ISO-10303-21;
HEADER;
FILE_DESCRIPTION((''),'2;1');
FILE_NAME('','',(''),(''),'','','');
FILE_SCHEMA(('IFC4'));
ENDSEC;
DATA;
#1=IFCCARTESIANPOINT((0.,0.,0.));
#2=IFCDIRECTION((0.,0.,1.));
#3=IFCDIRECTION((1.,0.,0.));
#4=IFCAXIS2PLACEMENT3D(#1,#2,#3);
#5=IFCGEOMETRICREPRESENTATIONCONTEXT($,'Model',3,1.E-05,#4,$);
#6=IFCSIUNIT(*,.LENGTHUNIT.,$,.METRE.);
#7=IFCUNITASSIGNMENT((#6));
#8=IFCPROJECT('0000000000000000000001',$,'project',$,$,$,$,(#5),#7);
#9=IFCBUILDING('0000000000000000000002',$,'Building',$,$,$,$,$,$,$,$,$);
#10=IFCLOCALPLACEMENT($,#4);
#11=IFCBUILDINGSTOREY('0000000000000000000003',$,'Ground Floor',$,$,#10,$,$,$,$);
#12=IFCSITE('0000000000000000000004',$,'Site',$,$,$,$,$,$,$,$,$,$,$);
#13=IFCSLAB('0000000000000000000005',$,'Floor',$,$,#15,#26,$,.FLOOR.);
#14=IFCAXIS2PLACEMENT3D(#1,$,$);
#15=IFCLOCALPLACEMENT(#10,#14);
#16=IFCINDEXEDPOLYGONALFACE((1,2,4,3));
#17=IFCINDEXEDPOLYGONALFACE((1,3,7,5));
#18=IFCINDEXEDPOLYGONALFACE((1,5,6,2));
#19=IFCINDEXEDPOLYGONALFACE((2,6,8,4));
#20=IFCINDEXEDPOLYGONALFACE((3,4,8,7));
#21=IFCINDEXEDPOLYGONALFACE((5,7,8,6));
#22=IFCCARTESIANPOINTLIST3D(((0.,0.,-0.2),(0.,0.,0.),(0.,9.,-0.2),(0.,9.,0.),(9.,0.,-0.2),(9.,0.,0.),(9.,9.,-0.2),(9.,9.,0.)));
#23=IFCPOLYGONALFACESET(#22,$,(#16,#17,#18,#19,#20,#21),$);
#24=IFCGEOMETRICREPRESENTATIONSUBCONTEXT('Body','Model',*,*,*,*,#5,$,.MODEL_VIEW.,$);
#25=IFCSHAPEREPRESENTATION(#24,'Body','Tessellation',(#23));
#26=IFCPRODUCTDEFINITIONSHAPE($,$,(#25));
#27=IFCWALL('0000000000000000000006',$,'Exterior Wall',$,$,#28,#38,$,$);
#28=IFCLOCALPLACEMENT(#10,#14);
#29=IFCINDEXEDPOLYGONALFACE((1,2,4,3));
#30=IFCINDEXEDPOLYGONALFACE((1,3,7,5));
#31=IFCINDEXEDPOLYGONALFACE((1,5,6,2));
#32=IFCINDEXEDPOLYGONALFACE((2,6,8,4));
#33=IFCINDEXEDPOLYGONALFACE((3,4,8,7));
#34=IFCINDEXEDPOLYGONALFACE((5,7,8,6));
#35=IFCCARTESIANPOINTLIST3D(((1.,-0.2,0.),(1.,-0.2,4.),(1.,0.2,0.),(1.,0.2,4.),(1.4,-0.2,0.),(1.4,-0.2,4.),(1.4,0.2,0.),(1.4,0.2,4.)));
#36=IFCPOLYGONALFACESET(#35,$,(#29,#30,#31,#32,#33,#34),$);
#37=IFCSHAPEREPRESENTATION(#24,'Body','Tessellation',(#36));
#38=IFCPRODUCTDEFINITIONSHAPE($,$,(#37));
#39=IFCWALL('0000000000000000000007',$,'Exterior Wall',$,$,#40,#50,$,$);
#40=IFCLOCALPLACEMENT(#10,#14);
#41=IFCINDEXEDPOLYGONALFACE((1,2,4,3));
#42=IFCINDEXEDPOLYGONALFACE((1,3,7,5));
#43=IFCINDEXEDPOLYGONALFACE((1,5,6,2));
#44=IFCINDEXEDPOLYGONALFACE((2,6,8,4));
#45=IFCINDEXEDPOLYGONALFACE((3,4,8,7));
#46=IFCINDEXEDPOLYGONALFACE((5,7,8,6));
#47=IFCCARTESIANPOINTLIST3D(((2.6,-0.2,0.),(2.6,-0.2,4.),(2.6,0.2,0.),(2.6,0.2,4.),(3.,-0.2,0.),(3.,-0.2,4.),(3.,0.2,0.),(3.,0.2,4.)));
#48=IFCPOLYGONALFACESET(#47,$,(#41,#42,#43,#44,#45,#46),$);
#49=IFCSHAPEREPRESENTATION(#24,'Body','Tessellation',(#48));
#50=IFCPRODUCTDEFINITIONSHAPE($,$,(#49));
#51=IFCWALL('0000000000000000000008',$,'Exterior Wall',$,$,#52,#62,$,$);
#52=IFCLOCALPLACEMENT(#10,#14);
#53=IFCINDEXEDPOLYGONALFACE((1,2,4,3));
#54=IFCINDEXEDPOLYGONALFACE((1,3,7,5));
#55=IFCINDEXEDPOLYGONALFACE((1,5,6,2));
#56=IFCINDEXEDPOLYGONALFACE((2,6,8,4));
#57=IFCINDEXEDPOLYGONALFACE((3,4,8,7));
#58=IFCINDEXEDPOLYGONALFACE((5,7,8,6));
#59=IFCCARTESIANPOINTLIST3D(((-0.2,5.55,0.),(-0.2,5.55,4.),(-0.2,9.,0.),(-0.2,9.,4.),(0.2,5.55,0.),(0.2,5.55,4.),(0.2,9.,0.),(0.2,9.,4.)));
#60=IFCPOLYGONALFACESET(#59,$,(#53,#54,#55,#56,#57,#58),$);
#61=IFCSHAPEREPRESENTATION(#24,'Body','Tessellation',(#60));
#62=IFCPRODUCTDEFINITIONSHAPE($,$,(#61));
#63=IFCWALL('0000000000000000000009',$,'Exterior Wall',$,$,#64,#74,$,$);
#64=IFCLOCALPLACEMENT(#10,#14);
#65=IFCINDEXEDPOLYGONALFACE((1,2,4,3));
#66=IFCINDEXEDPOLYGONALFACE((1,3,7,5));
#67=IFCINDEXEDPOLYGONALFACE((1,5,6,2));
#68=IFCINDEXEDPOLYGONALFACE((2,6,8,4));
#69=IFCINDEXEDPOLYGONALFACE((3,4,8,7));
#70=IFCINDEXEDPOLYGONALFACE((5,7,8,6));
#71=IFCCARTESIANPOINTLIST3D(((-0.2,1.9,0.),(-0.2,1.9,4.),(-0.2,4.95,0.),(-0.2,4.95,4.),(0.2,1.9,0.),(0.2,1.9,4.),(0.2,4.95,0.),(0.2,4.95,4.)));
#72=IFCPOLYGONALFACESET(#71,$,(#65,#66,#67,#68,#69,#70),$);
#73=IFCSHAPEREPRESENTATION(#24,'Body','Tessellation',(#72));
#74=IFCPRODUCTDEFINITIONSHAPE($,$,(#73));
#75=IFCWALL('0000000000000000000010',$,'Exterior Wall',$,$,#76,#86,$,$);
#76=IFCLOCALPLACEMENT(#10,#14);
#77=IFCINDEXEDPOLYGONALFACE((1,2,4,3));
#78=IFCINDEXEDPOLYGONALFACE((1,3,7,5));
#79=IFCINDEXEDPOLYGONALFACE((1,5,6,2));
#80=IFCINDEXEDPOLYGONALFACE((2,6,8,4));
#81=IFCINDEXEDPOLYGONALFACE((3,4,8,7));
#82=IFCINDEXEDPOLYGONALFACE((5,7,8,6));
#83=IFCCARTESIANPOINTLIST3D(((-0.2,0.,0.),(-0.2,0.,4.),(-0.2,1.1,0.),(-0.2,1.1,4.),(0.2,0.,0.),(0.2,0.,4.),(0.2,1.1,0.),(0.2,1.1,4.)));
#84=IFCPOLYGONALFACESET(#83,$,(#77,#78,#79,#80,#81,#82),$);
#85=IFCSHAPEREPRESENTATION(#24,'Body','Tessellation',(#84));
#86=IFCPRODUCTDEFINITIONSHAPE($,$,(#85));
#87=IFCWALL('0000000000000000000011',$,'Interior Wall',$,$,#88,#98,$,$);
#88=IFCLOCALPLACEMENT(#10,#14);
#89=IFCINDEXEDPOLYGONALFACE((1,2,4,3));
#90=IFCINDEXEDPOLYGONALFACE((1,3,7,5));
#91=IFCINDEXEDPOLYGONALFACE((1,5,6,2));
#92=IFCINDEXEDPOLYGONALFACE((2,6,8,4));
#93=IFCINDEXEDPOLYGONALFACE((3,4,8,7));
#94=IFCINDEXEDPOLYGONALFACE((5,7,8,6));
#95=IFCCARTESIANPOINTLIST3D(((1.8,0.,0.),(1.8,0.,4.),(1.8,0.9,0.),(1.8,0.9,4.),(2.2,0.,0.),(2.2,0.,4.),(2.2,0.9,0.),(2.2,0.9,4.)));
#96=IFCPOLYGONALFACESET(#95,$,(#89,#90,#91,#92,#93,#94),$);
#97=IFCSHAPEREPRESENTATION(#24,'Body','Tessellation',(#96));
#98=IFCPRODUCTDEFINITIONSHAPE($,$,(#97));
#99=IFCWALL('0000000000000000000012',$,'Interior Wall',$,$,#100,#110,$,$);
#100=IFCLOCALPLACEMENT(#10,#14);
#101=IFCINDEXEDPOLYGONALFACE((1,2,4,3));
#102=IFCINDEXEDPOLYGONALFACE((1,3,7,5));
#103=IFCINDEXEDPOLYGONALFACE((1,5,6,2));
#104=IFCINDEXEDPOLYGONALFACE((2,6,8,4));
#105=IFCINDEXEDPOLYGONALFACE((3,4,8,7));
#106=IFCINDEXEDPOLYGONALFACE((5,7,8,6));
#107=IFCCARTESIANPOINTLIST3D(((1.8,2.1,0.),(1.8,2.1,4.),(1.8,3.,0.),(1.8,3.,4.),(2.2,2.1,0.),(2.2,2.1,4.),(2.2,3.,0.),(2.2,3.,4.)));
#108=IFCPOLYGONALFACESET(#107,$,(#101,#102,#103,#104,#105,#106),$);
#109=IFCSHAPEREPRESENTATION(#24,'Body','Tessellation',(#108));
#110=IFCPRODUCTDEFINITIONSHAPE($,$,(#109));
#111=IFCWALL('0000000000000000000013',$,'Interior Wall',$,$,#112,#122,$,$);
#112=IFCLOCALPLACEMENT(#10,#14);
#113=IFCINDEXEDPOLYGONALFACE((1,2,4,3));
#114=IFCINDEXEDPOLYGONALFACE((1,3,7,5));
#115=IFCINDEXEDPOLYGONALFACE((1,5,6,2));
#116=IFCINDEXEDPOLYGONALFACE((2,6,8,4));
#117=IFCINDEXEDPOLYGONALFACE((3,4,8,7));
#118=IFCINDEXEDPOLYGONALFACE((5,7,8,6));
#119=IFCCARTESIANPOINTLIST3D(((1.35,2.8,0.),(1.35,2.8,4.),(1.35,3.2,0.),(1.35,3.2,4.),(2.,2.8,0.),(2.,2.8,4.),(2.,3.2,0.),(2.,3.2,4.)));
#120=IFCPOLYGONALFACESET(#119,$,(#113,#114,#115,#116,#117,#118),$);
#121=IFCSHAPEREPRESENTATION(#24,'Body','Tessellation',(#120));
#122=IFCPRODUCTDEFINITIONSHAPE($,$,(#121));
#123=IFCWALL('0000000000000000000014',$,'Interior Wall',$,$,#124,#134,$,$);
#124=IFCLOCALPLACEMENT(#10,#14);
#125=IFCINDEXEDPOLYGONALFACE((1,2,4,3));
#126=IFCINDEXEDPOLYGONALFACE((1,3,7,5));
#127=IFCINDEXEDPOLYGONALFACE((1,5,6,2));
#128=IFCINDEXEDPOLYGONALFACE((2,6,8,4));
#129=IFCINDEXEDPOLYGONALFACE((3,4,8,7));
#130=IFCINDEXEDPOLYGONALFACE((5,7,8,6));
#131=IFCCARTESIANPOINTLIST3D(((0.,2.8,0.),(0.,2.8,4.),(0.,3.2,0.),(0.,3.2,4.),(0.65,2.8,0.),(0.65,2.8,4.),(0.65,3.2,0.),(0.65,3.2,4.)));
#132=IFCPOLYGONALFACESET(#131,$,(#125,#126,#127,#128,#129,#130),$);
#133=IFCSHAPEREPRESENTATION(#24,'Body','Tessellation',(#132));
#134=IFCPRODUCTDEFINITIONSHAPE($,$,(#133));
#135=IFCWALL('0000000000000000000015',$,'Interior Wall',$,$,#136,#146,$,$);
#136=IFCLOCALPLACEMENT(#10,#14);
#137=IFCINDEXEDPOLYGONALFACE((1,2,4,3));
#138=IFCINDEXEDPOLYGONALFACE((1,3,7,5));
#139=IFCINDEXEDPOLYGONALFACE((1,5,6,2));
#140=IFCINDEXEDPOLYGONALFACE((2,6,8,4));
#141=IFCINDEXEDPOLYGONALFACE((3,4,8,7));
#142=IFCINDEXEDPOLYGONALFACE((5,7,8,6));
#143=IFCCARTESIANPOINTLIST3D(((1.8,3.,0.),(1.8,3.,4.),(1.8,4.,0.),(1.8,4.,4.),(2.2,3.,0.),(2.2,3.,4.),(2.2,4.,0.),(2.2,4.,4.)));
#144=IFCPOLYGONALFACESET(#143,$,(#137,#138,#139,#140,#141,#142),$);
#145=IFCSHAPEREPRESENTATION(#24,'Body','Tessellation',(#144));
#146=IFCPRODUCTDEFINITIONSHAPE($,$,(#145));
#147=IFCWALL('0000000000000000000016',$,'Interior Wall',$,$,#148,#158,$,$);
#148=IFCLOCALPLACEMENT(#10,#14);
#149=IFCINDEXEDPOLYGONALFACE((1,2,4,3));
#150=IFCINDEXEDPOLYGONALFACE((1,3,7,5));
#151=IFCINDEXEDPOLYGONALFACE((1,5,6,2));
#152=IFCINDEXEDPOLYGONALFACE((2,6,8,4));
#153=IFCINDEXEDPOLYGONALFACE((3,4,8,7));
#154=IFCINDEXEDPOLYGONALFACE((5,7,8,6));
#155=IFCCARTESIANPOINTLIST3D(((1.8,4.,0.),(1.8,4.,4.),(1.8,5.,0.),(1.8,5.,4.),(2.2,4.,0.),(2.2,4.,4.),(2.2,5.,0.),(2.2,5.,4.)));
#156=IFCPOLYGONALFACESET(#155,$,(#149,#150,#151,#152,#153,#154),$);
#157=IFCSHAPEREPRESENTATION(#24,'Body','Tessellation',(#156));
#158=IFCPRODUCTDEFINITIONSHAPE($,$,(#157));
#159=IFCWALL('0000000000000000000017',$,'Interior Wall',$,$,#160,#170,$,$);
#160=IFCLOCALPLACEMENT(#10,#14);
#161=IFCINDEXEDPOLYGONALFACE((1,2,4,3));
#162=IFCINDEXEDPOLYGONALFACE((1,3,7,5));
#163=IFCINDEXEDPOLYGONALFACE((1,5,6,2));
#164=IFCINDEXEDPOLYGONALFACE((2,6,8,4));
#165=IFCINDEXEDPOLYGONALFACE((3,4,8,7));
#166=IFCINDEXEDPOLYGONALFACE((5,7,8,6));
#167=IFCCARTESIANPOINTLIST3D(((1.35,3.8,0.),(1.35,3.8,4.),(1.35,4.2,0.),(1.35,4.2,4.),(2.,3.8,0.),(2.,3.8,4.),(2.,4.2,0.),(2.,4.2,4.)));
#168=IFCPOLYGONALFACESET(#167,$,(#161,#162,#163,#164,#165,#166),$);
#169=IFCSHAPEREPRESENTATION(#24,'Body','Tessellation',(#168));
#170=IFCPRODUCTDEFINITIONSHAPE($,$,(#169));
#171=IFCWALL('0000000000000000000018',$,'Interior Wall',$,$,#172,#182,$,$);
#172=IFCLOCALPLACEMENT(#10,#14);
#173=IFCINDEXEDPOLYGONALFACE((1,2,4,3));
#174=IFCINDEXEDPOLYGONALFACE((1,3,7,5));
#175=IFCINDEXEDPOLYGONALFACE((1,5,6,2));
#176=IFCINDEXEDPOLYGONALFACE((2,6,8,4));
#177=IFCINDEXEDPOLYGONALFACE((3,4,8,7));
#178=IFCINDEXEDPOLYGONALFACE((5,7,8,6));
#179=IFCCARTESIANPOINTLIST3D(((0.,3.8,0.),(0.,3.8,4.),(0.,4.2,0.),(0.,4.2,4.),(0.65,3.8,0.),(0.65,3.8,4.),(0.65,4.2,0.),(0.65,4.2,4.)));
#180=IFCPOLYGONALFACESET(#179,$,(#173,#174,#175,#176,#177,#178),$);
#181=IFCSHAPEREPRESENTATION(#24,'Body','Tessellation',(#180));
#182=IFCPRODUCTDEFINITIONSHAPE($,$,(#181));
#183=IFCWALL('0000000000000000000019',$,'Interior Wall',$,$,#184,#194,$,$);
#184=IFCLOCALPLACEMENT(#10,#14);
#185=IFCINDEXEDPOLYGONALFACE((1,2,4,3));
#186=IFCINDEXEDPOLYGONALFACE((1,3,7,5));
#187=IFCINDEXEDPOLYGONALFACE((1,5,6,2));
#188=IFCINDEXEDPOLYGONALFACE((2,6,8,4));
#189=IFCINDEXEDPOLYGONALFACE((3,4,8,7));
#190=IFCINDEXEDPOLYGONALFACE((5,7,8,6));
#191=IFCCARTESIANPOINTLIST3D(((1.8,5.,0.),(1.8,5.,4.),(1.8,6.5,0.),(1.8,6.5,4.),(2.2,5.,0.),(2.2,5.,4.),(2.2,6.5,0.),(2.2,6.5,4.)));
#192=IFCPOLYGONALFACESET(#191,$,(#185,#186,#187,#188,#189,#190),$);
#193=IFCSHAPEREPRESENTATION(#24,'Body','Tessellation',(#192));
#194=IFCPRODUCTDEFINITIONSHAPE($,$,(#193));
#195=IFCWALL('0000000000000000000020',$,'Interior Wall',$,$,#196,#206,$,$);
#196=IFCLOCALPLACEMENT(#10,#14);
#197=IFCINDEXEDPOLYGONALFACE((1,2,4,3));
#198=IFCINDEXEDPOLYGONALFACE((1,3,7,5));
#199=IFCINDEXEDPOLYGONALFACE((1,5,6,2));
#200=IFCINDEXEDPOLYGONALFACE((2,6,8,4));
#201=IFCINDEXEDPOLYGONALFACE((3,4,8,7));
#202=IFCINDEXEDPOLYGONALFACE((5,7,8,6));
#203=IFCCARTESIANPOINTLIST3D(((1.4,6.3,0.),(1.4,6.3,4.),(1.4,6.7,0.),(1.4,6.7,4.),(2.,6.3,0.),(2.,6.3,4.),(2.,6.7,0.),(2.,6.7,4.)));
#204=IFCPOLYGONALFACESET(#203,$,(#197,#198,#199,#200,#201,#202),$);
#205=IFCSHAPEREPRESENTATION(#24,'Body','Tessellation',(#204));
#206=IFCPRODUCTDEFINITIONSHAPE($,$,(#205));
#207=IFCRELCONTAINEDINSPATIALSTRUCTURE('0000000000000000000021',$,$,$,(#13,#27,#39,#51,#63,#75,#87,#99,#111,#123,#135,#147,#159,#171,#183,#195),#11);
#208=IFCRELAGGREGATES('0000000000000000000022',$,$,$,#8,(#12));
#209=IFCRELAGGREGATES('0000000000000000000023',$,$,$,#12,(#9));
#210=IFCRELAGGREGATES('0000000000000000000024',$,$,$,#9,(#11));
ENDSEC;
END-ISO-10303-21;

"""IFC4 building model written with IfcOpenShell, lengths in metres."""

from ifc_helpers import new_model, si_unit, frame, origin_with_axes, place, context, subcontext, project, spatial, indexed_curve, outline, extrude, element, save


model = new_model("IFC4")

# Units and contexts
model_context = context("Model", 3, precision=1e-05, world=origin_with_axes())
body_context = subcontext(model_context, "Body", "Model", "MODEL_VIEW")
ifc_project = project(units=[si_unit("LENGTHUNIT", "METRE")], contexts=[model_context])

# Site, building, storey
site = spatial("IfcSite", under=ifc_project, Name="Site")
building = spatial("IfcBuilding", under=site, Name="Building")
storey_placement = place(None, origin_with_axes())
storey = spatial("IfcBuildingStorey", under=building, at=storey_placement, Name="Ground Floor")

# Slab
slab_placement = place(storey_placement, frame((0.0, 0.0, -0.2), z_axis=(0.0, 0.0, 1.0), x_axis=(1.0, 0.0, 0.0)))
element("IfcSlab", 1, at=slab_placement, inside=storey, Name="Floor", PredefinedType="FLOOR", context=body_context, shape_type="SweptSolid", body=[
    extrude(outline(indexed_curve([(0.0, 0.0), (9.0, 0.0), (9.0, 9.0), (0.0, 9.0)])), None, (0.0, 0.0, 1.0), 0.2),
])

# Walls
for number, where, z_axis, x_axis, name in (
    (2, (1.0, 0.0, 0.0), (0.0, 0.0, 1.0), (1.0, 0.0, 0.0), "Exterior Wall"),
    (3, (2.6, 0.0, 0.0), (0.0, 0.0, 1.0), (1.0, 0.0, 0.0), "Exterior Wall"),
):
    element("IfcWall", number, at=place(storey_placement, frame(where, z_axis=z_axis, x_axis=x_axis)), inside=storey, Name=name, context=body_context, shape_type="SweptSolid", body=[
        extrude(outline(indexed_curve([(0.0, 0.0), (0.0, 0.4), (0.4, 0.4), (0.4, 0.0), (0.0, 0.0)], self_intersect=False)), frame((0.0, -0.2, 0.0), z_axis=(0.0, 0.0, 1.0), x_axis=(1.0, 0.0, 0.0)), (0.0, 0.0, 1.0), 4.0),
    ])
wall_1_placement = place(storey_placement, frame((0.0, 9.0, 0.0), z_axis=(0.0, 0.0, 1.0), x_axis=(0.0, -1.0, 0.0)))
element("IfcWall", 4, at=wall_1_placement, inside=storey, Name="Exterior Wall", context=body_context, shape_type="SweptSolid", body=[
    extrude(outline(indexed_curve([(0.0, 0.0), (0.0, 0.4), (3.45, 0.4), (3.45, 0.0), (0.0, 0.0)], self_intersect=False)), frame((0.0, -0.2, 0.0), z_axis=(0.0, 0.0, 1.0), x_axis=(1.0, 0.0, 0.0)), (0.0, 0.0, 1.0), 4.0),
])
wall_2_placement = place(storey_placement, frame((0.0, 4.95, 0.0), z_axis=(0.0, 0.0, 1.0), x_axis=(0.0, -1.0, 0.0)))
element("IfcWall", 5, at=wall_2_placement, inside=storey, Name="Exterior Wall", context=body_context, shape_type="SweptSolid", body=[
    extrude(outline(indexed_curve([(0.0, 0.0), (0.0, 0.4), (3.05, 0.4), (3.05, 0.0), (0.0, 0.0)], self_intersect=False)), frame((0.0, -0.2, 0.0), z_axis=(0.0, 0.0, 1.0), x_axis=(1.0, 0.0, 0.0)), (0.0, 0.0, 1.0), 4.0),
])
wall_3_placement = place(storey_placement, frame((0.0, 1.1, 0.0), z_axis=(0.0, 0.0, 1.0), x_axis=(0.0, -1.0, 0.0)))
element("IfcWall", 6, at=wall_3_placement, inside=storey, Name="Exterior Wall", context=body_context, shape_type="SweptSolid", body=[
    extrude(outline(indexed_curve([(0.0, 0.0), (0.0, 0.4), (1.1, 0.4), (1.1, 0.0), (0.0, 0.0)], self_intersect=False)), frame((0.0, -0.2, 0.0), z_axis=(0.0, 0.0, 1.0), x_axis=(1.0, 0.0, 0.0)), (0.0, 0.0, 1.0), 4.0),
])
wall_4_placement = place(storey_placement, frame((2.0, 0.0, 0.0), z_axis=(0.0, 0.0, 1.0), x_axis=(0.0, 1.0, 0.0)))
element("IfcWall", 7, at=wall_4_placement, inside=storey, Name="Interior Wall", context=body_context, shape_type="SweptSolid", body=[
    extrude(outline(indexed_curve([(0.0, 0.0), (0.0, 0.4), (0.9, 0.4), (0.9, 0.0), (0.0, 0.0)], self_intersect=False)), frame((0.0, -0.2, 0.0), z_axis=(0.0, 0.0, 1.0), x_axis=(1.0, 0.0, 0.0)), (0.0, 0.0, 1.0), 4.0),
])
wall_5_placement = place(storey_placement, frame((2.0, 2.1, 0.0), z_axis=(0.0, 0.0, 1.0), x_axis=(0.0, 1.0, 0.0)))
element("IfcWall", 8, at=wall_5_placement, inside=storey, Name="Interior Wall", context=body_context, shape_type="SweptSolid", body=[
    extrude(outline(indexed_curve([(0.0, 0.0), (0.0, 0.4), (0.9, 0.4), (0.9, 0.0), (0.0, 0.0)], self_intersect=False)), frame((0.0, -0.2, 0.0), z_axis=(0.0, 0.0, 1.0), x_axis=(1.0, 0.0, 0.0)), (0.0, 0.0, 1.0), 4.0),
])
for number, where, z_axis, x_axis, name in (
    (9, (2.0, 3.0, 0.0), (0.0, 0.0, 1.0), (-1.0, 0.0, 0.0), "Interior Wall"),
    (10, (0.65, 3.0, 0.0), (0.0, 0.0, 1.0), (-1.0, 0.0, 0.0), "Interior Wall"),
):
    element("IfcWall", number, at=place(storey_placement, frame(where, z_axis=z_axis, x_axis=x_axis)), inside=storey, Name=name, context=body_context, shape_type="SweptSolid", body=[
        extrude(outline(indexed_curve([(0.0, 0.0), (0.0, 0.4), (0.65, 0.4), (0.65, 0.0), (0.0, 0.0)], self_intersect=False)), frame((0.0, -0.2, 0.0), z_axis=(0.0, 0.0, 1.0), x_axis=(1.0, 0.0, 0.0)), (0.0, 0.0, 1.0), 4.0),
    ])
for number, where, z_axis, x_axis, name in (
    (11, (2.0, 4.0, 0.0), (0.0, 0.0, 1.0), (0.0, -1.0, 0.0), "Interior Wall"),
    (12, (2.0, 5.0, 0.0), (0.0, 0.0, 1.0), (0.0, -1.0, 0.0), "Interior Wall"),
):
    element("IfcWall", number, at=place(storey_placement, frame(where, z_axis=z_axis, x_axis=x_axis)), inside=storey, Name=name, context=body_context, shape_type="SweptSolid", body=[
        extrude(outline(indexed_curve([(0.0, 0.0), (0.0, 0.4), (1.0, 0.4), (1.0, 0.0), (0.0, 0.0)], self_intersect=False)), frame((0.0, -0.2, 0.0), z_axis=(0.0, 0.0, 1.0), x_axis=(1.0, 0.0, 0.0)), (0.0, 0.0, 1.0), 4.0),
    ])
for number, where, z_axis, x_axis, name in (
    (13, (2.0, 4.0, 0.0), (0.0, 0.0, 1.0), (-1.0, 0.0, 0.0), "Interior Wall"),
    (14, (0.65, 4.0, 0.0), (0.0, 0.0, 1.0), (-1.0, 0.0, 0.0), "Interior Wall"),
):
    element("IfcWall", number, at=place(storey_placement, frame(where, z_axis=z_axis, x_axis=x_axis)), inside=storey, Name=name, context=body_context, shape_type="SweptSolid", body=[
        extrude(outline(indexed_curve([(0.0, 0.0), (0.0, 0.4), (0.65, 0.4), (0.65, 0.0), (0.0, 0.0)], self_intersect=False)), frame((0.0, -0.2, 0.0), z_axis=(0.0, 0.0, 1.0), x_axis=(1.0, 0.0, 0.0)), (0.0, 0.0, 1.0), 4.0),
    ])
wall_6_placement = place(storey_placement, frame((2.0, 5.0, 0.0), z_axis=(0.0, 0.0, 1.0), x_axis=(0.0, 1.0, 0.0)))
element("IfcWall", 15, at=wall_6_placement, inside=storey, Name="Interior Wall", context=body_context, shape_type="SweptSolid", body=[
    extrude(outline(indexed_curve([(0.0, 0.0), (0.0, 0.4), (1.5, 0.4), (1.5, 0.0), (0.0, 0.0)], self_intersect=False)), frame((0.0, -0.2, 0.0), z_axis=(0.0, 0.0, 1.0), x_axis=(1.0, 0.0, 0.0)), (0.0, 0.0, 1.0), 4.0),
])
for number, where, z_axis, x_axis, name in (
    (16, (2.0, 6.5, 0.0), (0.0, 0.0, 1.0), (-1.0, 0.0, 0.0), "Interior Wall"),
):
    element("IfcWall", number, at=place(storey_placement, frame(where, z_axis=z_axis, x_axis=x_axis)), inside=storey, Name=name, context=body_context, shape_type="SweptSolid", body=[
        extrude(outline(indexed_curve([(0.0, 0.0), (0.0, 0.4), (0.6, 0.4), (0.6, 0.0), (0.0, 0.0)], self_intersect=False)), frame((0.0, -0.2, 0.0), z_axis=(0.0, 0.0, 1.0), x_axis=(1.0, 0.0, 0.0)), (0.0, 0.0, 1.0), 4.0),
    ])

save(model, "model.ifc")
